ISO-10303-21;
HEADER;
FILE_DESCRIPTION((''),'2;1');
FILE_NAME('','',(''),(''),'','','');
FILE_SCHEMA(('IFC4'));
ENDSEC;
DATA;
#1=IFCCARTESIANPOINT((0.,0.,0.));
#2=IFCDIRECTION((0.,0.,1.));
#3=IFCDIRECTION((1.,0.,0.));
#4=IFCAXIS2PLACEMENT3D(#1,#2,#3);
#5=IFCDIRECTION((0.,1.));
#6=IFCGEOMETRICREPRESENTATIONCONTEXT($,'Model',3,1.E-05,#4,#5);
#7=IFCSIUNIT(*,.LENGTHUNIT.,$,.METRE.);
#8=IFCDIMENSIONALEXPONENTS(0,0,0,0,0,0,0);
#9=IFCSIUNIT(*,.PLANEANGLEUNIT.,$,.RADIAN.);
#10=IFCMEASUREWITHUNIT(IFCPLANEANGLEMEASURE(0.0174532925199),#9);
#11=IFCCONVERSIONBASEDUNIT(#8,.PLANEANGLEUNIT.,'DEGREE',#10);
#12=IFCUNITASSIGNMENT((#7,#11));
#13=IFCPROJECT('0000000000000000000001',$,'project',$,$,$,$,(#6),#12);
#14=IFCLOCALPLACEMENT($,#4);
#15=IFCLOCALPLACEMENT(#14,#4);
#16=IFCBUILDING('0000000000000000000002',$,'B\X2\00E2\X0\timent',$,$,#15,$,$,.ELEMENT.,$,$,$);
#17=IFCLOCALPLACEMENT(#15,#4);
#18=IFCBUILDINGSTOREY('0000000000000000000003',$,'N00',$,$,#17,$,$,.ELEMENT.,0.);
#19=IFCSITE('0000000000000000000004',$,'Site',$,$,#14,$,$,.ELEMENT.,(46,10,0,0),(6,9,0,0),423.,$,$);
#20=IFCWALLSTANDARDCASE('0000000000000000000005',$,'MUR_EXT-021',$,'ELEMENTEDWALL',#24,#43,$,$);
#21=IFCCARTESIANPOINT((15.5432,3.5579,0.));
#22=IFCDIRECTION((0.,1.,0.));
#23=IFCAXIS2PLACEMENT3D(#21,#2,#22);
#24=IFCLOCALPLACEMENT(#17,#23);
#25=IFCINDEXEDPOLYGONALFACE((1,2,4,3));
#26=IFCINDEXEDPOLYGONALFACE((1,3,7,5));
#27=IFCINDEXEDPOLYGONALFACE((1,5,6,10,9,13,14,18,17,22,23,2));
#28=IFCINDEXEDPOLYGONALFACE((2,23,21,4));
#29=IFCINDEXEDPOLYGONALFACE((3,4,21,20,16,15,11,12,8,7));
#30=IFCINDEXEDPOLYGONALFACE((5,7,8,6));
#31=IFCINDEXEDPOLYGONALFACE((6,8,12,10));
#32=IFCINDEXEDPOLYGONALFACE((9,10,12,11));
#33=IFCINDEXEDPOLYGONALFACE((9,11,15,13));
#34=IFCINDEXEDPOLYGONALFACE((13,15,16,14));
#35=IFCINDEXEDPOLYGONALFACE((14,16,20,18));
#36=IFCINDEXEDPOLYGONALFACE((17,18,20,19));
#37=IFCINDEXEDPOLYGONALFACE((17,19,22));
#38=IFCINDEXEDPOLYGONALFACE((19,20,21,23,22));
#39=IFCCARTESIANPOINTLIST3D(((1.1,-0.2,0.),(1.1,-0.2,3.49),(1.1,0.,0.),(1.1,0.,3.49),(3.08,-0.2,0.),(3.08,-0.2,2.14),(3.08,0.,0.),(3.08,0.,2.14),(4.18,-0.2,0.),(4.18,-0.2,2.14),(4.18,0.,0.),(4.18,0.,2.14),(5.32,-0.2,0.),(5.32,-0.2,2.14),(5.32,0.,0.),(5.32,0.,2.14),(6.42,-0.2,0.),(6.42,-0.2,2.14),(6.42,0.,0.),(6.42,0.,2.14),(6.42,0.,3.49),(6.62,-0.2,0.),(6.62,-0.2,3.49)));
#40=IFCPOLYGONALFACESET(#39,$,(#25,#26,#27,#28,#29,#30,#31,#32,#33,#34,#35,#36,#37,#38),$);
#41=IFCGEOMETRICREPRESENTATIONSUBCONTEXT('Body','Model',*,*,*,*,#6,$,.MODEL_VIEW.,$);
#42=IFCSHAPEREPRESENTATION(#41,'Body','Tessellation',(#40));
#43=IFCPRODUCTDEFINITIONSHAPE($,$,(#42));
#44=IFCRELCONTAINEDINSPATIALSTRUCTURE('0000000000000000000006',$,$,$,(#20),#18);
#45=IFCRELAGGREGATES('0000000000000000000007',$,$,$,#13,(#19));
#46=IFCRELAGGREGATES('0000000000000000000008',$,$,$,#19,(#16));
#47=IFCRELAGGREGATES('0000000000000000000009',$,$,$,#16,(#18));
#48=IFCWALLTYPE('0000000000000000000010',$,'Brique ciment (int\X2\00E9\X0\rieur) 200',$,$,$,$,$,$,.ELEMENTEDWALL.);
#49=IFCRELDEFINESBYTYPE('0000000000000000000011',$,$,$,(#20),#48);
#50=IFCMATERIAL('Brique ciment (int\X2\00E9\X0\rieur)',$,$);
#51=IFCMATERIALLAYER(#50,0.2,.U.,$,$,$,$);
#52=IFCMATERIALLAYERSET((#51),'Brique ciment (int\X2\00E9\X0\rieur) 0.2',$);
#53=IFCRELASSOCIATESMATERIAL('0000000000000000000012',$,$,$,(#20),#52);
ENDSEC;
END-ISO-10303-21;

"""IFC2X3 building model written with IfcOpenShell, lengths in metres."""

from ifc_helpers import new_model, entity, si_unit, converted_unit, direction, frame, origin_with_axes, origin_2d_with_axis, place, context, subcontext, project, spatial, polyline, rectangle, outline, extrude, material, layer, layer_set, layer_usage, type_object, element, save


model = new_model("IFC2X3")

# Units and contexts
model_context = context("Model", 3, precision=1e-05, world=origin_with_axes(), true_north=direction((0.0, 1.0)))
body_context = subcontext(model_context, "Body", "Model", "MODEL_VIEW")
ifc_project = project(units=[si_unit("LENGTHUNIT", "METRE"), converted_unit("PLANEANGLEUNIT", "DEGREE", entity("IfcPlaneAngleMeasure", 0.0174532925199), si_unit("PLANEANGLEUNIT", "RADIAN"), dimensions=[0, 0, 0, 0, 0, 0, 0])], contexts=[model_context])

# Site, building, storey
site_placement = place(None, origin_with_axes())
site = spatial("IfcSite", under=ifc_project, at=site_placement, Name="Site", CompositionType="ELEMENT", RefLatitude=(46, 10, 0, 0), RefLongitude=(6, 9, 0, 0), RefElevation=423.0)
building_placement = place(site_placement, origin_with_axes())
building = spatial("IfcBuilding", under=site, at=building_placement, Name="Bâtiment", CompositionType="ELEMENT")
storey_placement = place(building_placement, origin_with_axes())
storey = spatial("IfcBuildingStorey", under=building, at=storey_placement, Name="N00", CompositionType="ELEMENT", Elevation=0.0)

# Shared definitions
ifc_material_1 = material(Name="Brique ciment (intérieur)")
ifc_layer_1 = layer(ifc_material_1, 0.2, ventilated="UNKNOWN")
ifc_layer_set_1 = layer_set([ifc_layer_1], Name="Brique ciment (intérieur) 0.2")
wall_type_1 = type_object("IfcWallType", Name="Brique ciment (intérieur) 200", PredefinedType="ELEMENTEDWALL")

# Wall, openings
ifc_layer_usage_1 = layer_usage(ifc_layer_set_1, "AXIS2", "POSITIVE", -0.2)
wall_1_placement = place(storey_placement, frame((15.5432, 3.5579, 0.0), z_axis=(0.0, 0.0, 1.0), x_axis=(0.0, 1.0, 0.0)))
wall_1 = element("IfcWallStandardCase", 1, at=wall_1_placement, inside=storey, type_object=wall_type_1, material=ifc_layer_usage_1, Name="MUR_EXT-021", ObjectType="ELEMENTEDWALL", context=body_context, shape_type="SweptSolid", body=[
    extrude(outline(polyline([(0.0, -0.2), (6.62, -0.2), (6.42, 0.0), (0.0, 0.0), (0.0, -0.2)])), origin_with_axes(), (0.0, 0.0, 1.0), 3.49),
])
opening_1_placement = place(wall_1_placement, frame((5.87, 0.0, 0.0), z_axis=(0.0, 0.0, 1.0), x_axis=(1.0, 0.0, 0.0)))
element("IfcOpeningElement", 2, at=opening_1_placement, cuts=wall_1, context=body_context, shape_type="SweptSolid", body=[
    extrude(rectangle(XDim=1.1, YDim=2.14, at=origin_2d_with_axis()), frame((0.0, 0.2, 1.07), z_axis=(0.0, -1.0, 0.0), x_axis=(1.0, 0.0, 0.0)), (0.0, 0.0, 1.0), 0.6),
])
opening_2_placement = place(wall_1_placement, frame((3.63, 0.0, 0.0), z_axis=(0.0, 0.0, 1.0), x_axis=(1.0, 0.0, 0.0)))
element("IfcOpeningElement", 3, at=opening_2_placement, cuts=wall_1, context=body_context, shape_type="SweptSolid", body=[
    extrude(rectangle(XDim=1.1, YDim=2.14, at=origin_2d_with_axis()), frame((0.0, 0.2, 1.07), z_axis=(0.0, -1.0, 0.0), x_axis=(1.0, 0.0, 0.0)), (0.0, 0.0, 1.0), 0.6),
])
opening_3_placement = place(wall_1_placement, frame((0.55, 0.0, 0.0), z_axis=(0.0, 0.0, 1.0), x_axis=(1.0, 0.0, 0.0)))
element("IfcOpeningElement", 4, at=opening_3_placement, cuts=wall_1, context=body_context, shape_type="SweptSolid", body=[
    extrude(rectangle(XDim=1.1, YDim=3.49, at=origin_2d_with_axis()), frame((0.0, 0.2, 1.745), z_axis=(0.0, 1.0, 0.0), x_axis=(-1.0, 0.0, 0.0)), (0.0, 0.0, -1.0), 0.6),
])

save(model, "model.ifc")
